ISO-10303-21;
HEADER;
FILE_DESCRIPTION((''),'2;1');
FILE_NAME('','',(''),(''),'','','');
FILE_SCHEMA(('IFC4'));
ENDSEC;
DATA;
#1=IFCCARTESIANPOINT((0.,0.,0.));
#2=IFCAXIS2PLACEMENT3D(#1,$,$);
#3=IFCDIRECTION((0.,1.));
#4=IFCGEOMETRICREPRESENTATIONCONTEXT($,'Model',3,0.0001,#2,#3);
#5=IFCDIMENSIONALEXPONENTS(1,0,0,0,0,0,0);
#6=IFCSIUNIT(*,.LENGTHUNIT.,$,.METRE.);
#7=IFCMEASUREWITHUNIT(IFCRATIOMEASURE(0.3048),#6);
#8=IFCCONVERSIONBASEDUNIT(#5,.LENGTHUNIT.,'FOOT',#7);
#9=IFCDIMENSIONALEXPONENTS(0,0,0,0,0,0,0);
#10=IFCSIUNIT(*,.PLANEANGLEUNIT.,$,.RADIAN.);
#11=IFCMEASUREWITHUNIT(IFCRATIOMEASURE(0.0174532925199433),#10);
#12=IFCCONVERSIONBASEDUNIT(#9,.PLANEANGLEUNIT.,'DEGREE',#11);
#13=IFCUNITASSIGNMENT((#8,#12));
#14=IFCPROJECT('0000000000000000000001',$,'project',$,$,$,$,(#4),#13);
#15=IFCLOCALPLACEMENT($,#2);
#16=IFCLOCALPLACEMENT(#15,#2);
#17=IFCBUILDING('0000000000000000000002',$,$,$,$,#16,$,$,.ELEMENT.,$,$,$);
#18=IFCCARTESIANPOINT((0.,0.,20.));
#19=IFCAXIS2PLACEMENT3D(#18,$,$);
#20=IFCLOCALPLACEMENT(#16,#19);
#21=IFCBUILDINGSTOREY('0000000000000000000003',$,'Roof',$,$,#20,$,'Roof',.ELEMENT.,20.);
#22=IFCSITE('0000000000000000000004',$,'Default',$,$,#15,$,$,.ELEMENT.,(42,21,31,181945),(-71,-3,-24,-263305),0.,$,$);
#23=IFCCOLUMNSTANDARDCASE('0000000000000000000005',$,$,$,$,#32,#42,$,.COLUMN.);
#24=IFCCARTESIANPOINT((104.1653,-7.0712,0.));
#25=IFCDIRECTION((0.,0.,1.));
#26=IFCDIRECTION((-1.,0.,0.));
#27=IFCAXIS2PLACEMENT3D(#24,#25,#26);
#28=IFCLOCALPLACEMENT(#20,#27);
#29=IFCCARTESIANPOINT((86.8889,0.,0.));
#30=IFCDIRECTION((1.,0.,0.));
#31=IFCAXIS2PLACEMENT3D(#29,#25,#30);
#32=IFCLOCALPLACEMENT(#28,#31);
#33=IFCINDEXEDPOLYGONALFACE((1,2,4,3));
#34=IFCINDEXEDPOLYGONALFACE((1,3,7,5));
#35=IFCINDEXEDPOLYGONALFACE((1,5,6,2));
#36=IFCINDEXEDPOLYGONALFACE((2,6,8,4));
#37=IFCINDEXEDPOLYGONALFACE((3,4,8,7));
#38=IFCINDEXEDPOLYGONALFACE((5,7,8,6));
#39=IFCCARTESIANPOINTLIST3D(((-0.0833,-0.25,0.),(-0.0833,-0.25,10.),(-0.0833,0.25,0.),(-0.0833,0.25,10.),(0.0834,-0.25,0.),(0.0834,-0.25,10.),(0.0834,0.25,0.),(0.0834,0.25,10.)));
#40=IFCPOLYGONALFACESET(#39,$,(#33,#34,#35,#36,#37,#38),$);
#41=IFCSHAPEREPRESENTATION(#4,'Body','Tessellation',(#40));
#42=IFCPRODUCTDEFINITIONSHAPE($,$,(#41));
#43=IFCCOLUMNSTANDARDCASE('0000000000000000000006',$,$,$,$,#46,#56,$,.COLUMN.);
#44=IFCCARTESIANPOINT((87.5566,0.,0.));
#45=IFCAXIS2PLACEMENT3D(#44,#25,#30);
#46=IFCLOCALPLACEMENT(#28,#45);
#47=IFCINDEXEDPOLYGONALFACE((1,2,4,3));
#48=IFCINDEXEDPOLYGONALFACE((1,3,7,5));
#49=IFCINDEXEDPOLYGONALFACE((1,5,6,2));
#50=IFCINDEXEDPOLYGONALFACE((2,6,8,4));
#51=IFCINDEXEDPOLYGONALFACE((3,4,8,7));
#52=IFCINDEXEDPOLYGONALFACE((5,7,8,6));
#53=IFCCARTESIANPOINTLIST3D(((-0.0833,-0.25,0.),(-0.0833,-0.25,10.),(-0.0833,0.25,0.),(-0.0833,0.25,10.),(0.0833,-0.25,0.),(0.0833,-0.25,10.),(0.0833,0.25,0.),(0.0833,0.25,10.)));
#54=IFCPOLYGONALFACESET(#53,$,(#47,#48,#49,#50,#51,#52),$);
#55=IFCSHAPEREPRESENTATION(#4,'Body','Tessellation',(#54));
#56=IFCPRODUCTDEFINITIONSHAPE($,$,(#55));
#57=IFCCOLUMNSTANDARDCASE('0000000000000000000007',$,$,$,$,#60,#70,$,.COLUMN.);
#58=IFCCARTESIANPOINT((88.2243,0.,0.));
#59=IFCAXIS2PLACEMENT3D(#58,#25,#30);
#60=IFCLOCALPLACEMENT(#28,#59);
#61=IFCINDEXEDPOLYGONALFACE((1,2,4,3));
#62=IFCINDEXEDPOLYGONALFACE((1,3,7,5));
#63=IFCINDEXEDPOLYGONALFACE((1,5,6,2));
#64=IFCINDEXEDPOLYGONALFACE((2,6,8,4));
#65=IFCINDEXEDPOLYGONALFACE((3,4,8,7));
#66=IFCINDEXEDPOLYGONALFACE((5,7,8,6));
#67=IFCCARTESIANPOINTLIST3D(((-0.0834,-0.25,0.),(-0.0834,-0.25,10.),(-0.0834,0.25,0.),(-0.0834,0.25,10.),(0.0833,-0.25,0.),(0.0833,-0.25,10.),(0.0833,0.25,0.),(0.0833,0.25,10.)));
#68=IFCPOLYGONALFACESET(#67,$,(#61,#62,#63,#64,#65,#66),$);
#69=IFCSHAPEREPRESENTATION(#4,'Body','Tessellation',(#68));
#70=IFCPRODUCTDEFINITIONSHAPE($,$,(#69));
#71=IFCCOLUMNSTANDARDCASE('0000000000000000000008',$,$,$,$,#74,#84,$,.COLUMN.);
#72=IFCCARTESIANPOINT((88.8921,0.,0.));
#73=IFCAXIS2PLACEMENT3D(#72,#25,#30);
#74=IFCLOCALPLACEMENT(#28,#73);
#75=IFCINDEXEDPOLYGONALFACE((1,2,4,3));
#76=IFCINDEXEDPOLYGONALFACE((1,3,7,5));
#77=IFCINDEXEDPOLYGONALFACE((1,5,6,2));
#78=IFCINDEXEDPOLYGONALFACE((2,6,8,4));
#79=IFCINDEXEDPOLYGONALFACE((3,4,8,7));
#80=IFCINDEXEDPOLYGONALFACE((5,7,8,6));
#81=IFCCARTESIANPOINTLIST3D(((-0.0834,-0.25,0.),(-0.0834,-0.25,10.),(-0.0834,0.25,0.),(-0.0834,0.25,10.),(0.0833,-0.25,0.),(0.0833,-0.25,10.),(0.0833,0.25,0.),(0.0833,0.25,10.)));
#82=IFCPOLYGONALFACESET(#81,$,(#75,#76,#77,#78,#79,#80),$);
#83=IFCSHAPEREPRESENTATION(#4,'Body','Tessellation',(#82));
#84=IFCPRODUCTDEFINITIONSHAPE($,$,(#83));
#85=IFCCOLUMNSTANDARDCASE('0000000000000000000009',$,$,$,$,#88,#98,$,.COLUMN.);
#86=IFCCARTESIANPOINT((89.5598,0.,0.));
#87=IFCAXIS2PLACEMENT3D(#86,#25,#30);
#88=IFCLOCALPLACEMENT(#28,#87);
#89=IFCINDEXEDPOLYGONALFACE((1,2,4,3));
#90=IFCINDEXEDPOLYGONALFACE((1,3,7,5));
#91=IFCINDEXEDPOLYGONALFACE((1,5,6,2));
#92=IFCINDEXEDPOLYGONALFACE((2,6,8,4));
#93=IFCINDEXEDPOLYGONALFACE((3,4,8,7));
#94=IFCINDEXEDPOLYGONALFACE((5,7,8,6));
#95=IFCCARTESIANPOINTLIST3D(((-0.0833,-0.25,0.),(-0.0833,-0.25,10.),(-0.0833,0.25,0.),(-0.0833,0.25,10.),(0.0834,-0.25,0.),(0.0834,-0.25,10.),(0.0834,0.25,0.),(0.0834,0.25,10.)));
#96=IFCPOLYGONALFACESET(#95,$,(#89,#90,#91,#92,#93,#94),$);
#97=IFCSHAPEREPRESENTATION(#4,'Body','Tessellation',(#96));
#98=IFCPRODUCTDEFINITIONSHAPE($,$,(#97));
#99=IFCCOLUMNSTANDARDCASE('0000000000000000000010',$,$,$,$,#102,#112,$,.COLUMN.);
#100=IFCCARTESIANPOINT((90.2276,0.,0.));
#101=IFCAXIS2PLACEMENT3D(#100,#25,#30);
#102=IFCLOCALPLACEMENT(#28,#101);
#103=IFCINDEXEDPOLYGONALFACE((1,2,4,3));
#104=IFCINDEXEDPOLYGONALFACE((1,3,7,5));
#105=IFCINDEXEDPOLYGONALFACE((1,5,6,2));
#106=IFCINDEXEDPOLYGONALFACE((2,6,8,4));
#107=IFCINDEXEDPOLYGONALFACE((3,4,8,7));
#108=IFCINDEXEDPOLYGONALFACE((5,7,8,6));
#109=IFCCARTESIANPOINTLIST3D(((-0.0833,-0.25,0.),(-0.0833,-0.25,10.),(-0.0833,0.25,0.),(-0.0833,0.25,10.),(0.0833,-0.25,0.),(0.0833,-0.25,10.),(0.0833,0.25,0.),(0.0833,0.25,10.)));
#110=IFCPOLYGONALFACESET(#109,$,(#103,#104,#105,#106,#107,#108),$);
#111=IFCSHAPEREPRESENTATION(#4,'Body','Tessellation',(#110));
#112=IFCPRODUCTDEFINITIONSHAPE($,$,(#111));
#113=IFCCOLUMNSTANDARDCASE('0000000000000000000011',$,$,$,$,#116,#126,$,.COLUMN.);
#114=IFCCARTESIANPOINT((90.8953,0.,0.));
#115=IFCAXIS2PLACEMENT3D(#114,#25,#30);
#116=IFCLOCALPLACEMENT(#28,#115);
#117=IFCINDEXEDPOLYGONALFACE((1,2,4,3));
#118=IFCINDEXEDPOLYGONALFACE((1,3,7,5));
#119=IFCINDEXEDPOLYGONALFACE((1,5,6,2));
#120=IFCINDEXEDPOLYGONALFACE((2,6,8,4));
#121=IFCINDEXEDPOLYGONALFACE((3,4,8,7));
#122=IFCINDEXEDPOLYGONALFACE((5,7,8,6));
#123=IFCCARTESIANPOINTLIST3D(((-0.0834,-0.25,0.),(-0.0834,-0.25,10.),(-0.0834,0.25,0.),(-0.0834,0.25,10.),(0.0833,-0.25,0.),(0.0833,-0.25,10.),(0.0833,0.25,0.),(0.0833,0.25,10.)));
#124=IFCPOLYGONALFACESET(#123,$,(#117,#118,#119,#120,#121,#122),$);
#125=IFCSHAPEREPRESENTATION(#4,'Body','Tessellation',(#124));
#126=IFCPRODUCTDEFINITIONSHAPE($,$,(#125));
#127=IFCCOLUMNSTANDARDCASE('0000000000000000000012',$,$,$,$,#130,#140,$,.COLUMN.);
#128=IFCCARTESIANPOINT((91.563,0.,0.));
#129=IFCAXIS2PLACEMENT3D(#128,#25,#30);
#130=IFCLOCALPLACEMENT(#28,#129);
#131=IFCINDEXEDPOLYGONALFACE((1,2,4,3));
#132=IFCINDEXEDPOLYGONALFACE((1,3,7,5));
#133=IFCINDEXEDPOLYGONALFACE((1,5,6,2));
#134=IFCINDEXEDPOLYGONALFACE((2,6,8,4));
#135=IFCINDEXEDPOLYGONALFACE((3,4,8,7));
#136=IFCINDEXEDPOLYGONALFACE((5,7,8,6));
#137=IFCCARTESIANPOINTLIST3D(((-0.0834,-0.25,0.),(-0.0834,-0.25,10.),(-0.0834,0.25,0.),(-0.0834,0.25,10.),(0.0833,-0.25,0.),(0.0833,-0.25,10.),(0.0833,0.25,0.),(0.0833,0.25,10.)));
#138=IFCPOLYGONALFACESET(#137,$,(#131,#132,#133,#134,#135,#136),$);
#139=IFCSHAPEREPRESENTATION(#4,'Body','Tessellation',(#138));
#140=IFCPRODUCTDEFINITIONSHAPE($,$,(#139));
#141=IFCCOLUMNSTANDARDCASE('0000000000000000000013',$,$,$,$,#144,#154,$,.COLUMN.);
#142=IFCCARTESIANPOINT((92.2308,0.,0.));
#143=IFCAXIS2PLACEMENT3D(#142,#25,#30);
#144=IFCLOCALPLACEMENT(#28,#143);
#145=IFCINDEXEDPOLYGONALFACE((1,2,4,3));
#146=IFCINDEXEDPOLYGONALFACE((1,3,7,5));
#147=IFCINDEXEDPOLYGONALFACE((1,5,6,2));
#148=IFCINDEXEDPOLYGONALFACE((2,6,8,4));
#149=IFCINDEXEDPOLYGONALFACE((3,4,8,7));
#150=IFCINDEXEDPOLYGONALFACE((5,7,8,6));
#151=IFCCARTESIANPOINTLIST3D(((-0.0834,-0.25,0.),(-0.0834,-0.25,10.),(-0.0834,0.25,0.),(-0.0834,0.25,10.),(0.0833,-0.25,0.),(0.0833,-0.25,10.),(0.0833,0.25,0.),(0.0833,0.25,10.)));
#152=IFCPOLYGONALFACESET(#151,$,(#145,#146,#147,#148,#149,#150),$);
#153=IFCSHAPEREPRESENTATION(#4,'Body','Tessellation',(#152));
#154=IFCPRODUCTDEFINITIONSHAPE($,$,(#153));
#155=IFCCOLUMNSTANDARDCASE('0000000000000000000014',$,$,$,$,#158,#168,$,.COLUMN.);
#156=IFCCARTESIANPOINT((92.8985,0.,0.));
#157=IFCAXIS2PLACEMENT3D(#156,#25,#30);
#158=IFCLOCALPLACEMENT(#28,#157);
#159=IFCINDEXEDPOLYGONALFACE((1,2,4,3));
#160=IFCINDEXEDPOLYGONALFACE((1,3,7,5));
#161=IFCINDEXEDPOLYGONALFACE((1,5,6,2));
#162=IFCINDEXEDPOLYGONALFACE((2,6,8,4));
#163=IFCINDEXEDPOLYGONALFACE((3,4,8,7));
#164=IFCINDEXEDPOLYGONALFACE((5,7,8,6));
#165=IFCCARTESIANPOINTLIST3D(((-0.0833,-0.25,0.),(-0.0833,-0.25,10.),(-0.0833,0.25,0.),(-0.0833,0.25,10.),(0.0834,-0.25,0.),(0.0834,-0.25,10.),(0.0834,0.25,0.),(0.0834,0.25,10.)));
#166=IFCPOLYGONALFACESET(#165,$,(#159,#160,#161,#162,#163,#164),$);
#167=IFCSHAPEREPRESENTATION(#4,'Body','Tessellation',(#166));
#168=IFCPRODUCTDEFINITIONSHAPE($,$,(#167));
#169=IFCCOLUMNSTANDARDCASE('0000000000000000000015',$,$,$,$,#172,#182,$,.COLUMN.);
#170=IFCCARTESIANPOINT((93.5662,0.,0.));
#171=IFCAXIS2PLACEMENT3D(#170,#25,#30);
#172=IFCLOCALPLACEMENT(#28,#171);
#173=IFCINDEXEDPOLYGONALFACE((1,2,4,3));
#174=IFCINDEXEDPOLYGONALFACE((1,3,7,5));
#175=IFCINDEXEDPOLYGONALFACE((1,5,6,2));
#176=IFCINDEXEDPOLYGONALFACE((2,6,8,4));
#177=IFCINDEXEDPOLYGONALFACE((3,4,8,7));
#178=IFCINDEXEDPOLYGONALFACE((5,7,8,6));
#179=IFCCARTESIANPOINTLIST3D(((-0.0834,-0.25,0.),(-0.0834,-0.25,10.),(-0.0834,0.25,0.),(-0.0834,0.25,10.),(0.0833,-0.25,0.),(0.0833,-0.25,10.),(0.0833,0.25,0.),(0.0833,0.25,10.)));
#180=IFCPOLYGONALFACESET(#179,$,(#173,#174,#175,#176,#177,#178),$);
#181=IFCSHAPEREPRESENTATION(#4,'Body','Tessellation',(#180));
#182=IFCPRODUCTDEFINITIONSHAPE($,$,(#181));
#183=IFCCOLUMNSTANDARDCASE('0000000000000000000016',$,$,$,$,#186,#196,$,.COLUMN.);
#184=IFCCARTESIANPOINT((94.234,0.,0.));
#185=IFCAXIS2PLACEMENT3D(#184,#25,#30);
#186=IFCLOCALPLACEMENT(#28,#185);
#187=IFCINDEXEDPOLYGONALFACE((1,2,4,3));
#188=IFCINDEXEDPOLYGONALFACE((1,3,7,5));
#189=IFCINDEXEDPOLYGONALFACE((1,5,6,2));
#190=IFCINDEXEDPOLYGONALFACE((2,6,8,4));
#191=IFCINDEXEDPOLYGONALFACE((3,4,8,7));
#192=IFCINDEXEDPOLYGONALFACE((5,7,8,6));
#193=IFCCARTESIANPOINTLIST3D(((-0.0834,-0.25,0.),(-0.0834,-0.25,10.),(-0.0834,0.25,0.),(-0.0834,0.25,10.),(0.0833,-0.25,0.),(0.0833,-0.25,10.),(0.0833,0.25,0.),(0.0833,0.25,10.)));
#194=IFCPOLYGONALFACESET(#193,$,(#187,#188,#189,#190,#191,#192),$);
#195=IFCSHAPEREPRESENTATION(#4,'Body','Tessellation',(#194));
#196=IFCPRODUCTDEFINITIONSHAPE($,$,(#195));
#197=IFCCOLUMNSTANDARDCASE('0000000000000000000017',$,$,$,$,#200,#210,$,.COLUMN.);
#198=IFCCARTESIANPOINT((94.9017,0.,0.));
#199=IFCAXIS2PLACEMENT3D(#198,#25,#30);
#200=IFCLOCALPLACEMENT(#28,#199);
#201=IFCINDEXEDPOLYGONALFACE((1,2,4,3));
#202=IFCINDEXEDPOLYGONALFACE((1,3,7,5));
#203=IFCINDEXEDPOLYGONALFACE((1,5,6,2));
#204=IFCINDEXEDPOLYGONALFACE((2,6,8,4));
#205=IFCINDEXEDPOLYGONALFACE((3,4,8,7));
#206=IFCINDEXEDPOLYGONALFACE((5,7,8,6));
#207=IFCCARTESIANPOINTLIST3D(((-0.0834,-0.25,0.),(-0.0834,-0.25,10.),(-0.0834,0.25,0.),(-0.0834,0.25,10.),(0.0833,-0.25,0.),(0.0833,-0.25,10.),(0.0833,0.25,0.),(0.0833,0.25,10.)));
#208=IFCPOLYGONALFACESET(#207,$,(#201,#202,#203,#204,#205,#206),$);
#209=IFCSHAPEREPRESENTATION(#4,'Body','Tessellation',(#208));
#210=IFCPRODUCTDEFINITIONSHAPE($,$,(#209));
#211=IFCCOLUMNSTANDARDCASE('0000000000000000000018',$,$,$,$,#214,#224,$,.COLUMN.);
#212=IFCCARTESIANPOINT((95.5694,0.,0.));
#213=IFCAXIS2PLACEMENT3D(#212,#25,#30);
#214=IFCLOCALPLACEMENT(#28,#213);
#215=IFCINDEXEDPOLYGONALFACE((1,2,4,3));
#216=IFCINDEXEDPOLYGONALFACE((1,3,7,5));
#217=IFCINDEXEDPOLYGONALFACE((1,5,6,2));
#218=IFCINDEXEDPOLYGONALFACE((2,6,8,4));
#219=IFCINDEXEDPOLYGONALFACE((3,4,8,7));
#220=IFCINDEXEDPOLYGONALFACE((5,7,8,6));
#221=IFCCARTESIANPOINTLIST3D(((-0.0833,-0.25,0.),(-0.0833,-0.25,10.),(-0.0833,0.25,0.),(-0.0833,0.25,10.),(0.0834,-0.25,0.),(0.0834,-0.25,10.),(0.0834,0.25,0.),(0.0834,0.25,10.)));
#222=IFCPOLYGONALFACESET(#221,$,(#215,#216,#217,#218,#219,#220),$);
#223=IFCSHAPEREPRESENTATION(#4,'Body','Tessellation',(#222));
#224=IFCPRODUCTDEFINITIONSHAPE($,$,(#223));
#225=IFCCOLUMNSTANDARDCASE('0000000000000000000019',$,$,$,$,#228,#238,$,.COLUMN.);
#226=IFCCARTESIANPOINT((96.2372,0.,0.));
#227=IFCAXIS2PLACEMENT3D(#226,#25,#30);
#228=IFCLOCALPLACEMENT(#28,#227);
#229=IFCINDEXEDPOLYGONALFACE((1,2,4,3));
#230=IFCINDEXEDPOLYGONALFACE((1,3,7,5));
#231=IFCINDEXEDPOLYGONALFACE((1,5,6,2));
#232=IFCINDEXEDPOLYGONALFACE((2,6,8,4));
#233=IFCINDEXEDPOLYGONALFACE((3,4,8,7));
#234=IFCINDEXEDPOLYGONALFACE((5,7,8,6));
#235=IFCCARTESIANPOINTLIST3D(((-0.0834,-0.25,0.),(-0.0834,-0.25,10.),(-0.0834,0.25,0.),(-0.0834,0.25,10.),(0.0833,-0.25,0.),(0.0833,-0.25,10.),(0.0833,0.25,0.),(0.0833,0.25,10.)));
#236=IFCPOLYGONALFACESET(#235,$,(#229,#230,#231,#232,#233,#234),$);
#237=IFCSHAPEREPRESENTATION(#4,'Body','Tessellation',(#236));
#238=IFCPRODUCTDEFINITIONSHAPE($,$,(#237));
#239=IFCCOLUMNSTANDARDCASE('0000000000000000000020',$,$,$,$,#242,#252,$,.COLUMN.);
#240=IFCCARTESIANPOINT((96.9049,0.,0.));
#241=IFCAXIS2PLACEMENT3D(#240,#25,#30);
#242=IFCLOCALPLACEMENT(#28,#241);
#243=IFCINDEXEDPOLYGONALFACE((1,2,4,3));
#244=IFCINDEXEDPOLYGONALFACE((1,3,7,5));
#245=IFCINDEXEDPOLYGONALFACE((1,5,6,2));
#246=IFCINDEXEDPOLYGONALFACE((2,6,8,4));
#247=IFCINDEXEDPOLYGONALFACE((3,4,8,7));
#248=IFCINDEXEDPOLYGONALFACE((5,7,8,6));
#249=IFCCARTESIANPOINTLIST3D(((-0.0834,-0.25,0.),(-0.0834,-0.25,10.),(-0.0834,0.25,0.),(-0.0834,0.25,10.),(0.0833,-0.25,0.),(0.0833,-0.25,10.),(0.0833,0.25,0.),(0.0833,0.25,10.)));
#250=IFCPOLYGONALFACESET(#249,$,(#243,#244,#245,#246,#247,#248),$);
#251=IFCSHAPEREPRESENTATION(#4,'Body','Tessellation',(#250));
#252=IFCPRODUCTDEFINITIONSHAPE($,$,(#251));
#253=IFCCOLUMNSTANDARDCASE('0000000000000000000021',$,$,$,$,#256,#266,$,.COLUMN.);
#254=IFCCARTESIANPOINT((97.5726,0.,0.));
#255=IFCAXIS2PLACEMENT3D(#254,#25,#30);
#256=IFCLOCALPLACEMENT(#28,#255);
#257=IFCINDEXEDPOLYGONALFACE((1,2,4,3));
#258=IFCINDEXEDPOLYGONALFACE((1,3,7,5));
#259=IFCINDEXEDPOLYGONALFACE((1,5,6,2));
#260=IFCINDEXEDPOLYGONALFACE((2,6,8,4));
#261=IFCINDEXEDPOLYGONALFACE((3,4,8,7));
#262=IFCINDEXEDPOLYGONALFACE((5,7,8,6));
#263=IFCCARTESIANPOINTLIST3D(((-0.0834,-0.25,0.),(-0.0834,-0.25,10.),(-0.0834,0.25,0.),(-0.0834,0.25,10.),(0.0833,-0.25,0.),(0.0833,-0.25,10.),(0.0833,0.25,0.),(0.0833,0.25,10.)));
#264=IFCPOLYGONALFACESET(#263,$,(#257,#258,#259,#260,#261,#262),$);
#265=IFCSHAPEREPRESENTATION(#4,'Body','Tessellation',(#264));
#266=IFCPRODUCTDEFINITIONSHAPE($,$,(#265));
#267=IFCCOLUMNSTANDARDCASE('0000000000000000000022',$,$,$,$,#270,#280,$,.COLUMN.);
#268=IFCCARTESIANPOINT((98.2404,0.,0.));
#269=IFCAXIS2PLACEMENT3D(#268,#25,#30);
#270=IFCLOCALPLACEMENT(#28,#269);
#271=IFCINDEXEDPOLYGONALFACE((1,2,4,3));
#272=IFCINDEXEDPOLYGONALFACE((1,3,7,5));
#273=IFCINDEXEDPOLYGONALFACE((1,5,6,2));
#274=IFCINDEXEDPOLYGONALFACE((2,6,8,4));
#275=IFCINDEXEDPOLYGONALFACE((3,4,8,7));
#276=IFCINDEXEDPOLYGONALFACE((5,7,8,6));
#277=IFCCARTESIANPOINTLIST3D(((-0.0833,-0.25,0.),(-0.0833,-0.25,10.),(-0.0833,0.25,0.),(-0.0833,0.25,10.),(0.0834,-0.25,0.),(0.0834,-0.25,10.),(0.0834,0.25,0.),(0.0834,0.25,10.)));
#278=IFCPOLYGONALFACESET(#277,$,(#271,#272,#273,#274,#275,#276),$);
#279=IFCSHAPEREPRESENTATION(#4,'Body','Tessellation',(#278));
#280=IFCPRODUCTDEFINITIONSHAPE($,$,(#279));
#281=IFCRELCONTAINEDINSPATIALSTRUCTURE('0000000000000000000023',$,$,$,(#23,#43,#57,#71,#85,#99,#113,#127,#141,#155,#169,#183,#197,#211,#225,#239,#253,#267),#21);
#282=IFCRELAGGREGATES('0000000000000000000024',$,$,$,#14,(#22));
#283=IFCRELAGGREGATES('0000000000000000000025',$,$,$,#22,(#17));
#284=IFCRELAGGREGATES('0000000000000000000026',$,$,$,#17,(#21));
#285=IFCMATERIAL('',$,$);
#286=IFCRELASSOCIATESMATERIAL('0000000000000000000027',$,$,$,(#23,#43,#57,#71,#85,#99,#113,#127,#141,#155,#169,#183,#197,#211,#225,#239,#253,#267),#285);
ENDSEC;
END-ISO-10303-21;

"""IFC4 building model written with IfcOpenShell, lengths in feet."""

from ifc_helpers import new_model, entity, si_unit, converted_unit, direction, frame, origin, place, context, project, spatial, rectangle, extrude, material, element, save


model = new_model("IFC4")

# Units and contexts
model_context = context("Model", 3, precision=0.0001, world=origin(), true_north=direction((0.0, 1.0)))
ifc_project = project(units=[converted_unit("LENGTHUNIT", "FOOT", entity("IfcRatioMeasure", 0.3048), si_unit("LENGTHUNIT", "METRE"), dimensions=[1, 0, 0, 0, 0, 0, 0]), converted_unit("PLANEANGLEUNIT", "DEGREE", entity("IfcRatioMeasure", 0.0174532925199433), si_unit("PLANEANGLEUNIT", "RADIAN"), dimensions=[0, 0, 0, 0, 0, 0, 0])], contexts=[model_context])

# Site, building, storey
site_placement = place(None, origin())
site = spatial("IfcSite", under=ifc_project, at=site_placement, Name="Default", CompositionType="ELEMENT", RefLatitude=(42, 21, 31, 181945), RefLongitude=(-71, -3, -24, -263305), RefElevation=0.0)
building_placement = place(site_placement, origin())
building = spatial("IfcBuilding", under=site, at=building_placement, CompositionType="ELEMENT")
storey_placement = place(building_placement, frame((0.0, 0.0, 20.0)))
storey = spatial("IfcBuildingStorey", under=building, at=storey_placement, Name="Roof", LongName="Roof", CompositionType="ELEMENT", Elevation=20.0)

# Columns
ifc_material = material(Name="")
placement = place(storey_placement, frame((104.1653, -7.0712, 0.0), z_axis=(0.0, 0.0, 1.0), x_axis=(-1.0, 0.0, 0.0)))
for number, where, z_axis, x_axis in (
    (1, (86.8889, 0.0, 0.0), (0.0, 0.0, 1.0), (1.0, 0.0, 0.0)),
    (2, (87.5566, 0.0, 0.0), (0.0, 0.0, 1.0), (1.0, 0.0, 0.0)),
    (3, (88.2243, 0.0, 0.0), (0.0, 0.0, 1.0), (1.0, 0.0, 0.0)),
    (4, (88.8921, 0.0, 0.0), (0.0, 0.0, 1.0), (1.0, 0.0, 0.0)),
    (5, (89.5598, 0.0, 0.0), (0.0, 0.0, 1.0), (1.0, 0.0, 0.0)),
    (6, (90.2276, 0.0, 0.0), (0.0, 0.0, 1.0), (1.0, 0.0, 0.0)),
    (7, (90.8953, 0.0, 0.0), (0.0, 0.0, 1.0), (1.0, 0.0, 0.0)),
    (8, (91.563, 0.0, 0.0), (0.0, 0.0, 1.0), (1.0, 0.0, 0.0)),
    (9, (92.2308, 0.0, 0.0), (0.0, 0.0, 1.0), (1.0, 0.0, 0.0)),
    (10, (92.8985, 0.0, 0.0), (0.0, 0.0, 1.0), (1.0, 0.0, 0.0)),
    (11, (93.5662, 0.0, 0.0), (0.0, 0.0, 1.0), (1.0, 0.0, 0.0)),
    (12, (94.234, 0.0, 0.0), (0.0, 0.0, 1.0), (1.0, 0.0, 0.0)),
    (13, (94.9017, 0.0, 0.0), (0.0, 0.0, 1.0), (1.0, 0.0, 0.0)),
    (14, (95.5694, 0.0, 0.0), (0.0, 0.0, 1.0), (1.0, 0.0, 0.0)),
    (15, (96.2372, 0.0, 0.0), (0.0, 0.0, 1.0), (1.0, 0.0, 0.0)),
    (16, (96.9049, 0.0, 0.0), (0.0, 0.0, 1.0), (1.0, 0.0, 0.0)),
    (17, (97.5726, 0.0, 0.0), (0.0, 0.0, 1.0), (1.0, 0.0, 0.0)),
    (18, (98.2404, 0.0, 0.0), (0.0, 0.0, 1.0), (1.0, 0.0, 0.0)),
):
    element("IfcColumnStandardCase", number, at=place(placement, frame(where, z_axis=z_axis, x_axis=x_axis)), inside=storey, material=ifc_material, PredefinedType="COLUMN", context=model_context, shape_type="SweptSolid", body=[
        extrude(rectangle(XDim=0.1667, YDim=0.5), origin(), (0.0, 0.0, 1.0), 10.0),
    ])

save(model, "model.ifc")
